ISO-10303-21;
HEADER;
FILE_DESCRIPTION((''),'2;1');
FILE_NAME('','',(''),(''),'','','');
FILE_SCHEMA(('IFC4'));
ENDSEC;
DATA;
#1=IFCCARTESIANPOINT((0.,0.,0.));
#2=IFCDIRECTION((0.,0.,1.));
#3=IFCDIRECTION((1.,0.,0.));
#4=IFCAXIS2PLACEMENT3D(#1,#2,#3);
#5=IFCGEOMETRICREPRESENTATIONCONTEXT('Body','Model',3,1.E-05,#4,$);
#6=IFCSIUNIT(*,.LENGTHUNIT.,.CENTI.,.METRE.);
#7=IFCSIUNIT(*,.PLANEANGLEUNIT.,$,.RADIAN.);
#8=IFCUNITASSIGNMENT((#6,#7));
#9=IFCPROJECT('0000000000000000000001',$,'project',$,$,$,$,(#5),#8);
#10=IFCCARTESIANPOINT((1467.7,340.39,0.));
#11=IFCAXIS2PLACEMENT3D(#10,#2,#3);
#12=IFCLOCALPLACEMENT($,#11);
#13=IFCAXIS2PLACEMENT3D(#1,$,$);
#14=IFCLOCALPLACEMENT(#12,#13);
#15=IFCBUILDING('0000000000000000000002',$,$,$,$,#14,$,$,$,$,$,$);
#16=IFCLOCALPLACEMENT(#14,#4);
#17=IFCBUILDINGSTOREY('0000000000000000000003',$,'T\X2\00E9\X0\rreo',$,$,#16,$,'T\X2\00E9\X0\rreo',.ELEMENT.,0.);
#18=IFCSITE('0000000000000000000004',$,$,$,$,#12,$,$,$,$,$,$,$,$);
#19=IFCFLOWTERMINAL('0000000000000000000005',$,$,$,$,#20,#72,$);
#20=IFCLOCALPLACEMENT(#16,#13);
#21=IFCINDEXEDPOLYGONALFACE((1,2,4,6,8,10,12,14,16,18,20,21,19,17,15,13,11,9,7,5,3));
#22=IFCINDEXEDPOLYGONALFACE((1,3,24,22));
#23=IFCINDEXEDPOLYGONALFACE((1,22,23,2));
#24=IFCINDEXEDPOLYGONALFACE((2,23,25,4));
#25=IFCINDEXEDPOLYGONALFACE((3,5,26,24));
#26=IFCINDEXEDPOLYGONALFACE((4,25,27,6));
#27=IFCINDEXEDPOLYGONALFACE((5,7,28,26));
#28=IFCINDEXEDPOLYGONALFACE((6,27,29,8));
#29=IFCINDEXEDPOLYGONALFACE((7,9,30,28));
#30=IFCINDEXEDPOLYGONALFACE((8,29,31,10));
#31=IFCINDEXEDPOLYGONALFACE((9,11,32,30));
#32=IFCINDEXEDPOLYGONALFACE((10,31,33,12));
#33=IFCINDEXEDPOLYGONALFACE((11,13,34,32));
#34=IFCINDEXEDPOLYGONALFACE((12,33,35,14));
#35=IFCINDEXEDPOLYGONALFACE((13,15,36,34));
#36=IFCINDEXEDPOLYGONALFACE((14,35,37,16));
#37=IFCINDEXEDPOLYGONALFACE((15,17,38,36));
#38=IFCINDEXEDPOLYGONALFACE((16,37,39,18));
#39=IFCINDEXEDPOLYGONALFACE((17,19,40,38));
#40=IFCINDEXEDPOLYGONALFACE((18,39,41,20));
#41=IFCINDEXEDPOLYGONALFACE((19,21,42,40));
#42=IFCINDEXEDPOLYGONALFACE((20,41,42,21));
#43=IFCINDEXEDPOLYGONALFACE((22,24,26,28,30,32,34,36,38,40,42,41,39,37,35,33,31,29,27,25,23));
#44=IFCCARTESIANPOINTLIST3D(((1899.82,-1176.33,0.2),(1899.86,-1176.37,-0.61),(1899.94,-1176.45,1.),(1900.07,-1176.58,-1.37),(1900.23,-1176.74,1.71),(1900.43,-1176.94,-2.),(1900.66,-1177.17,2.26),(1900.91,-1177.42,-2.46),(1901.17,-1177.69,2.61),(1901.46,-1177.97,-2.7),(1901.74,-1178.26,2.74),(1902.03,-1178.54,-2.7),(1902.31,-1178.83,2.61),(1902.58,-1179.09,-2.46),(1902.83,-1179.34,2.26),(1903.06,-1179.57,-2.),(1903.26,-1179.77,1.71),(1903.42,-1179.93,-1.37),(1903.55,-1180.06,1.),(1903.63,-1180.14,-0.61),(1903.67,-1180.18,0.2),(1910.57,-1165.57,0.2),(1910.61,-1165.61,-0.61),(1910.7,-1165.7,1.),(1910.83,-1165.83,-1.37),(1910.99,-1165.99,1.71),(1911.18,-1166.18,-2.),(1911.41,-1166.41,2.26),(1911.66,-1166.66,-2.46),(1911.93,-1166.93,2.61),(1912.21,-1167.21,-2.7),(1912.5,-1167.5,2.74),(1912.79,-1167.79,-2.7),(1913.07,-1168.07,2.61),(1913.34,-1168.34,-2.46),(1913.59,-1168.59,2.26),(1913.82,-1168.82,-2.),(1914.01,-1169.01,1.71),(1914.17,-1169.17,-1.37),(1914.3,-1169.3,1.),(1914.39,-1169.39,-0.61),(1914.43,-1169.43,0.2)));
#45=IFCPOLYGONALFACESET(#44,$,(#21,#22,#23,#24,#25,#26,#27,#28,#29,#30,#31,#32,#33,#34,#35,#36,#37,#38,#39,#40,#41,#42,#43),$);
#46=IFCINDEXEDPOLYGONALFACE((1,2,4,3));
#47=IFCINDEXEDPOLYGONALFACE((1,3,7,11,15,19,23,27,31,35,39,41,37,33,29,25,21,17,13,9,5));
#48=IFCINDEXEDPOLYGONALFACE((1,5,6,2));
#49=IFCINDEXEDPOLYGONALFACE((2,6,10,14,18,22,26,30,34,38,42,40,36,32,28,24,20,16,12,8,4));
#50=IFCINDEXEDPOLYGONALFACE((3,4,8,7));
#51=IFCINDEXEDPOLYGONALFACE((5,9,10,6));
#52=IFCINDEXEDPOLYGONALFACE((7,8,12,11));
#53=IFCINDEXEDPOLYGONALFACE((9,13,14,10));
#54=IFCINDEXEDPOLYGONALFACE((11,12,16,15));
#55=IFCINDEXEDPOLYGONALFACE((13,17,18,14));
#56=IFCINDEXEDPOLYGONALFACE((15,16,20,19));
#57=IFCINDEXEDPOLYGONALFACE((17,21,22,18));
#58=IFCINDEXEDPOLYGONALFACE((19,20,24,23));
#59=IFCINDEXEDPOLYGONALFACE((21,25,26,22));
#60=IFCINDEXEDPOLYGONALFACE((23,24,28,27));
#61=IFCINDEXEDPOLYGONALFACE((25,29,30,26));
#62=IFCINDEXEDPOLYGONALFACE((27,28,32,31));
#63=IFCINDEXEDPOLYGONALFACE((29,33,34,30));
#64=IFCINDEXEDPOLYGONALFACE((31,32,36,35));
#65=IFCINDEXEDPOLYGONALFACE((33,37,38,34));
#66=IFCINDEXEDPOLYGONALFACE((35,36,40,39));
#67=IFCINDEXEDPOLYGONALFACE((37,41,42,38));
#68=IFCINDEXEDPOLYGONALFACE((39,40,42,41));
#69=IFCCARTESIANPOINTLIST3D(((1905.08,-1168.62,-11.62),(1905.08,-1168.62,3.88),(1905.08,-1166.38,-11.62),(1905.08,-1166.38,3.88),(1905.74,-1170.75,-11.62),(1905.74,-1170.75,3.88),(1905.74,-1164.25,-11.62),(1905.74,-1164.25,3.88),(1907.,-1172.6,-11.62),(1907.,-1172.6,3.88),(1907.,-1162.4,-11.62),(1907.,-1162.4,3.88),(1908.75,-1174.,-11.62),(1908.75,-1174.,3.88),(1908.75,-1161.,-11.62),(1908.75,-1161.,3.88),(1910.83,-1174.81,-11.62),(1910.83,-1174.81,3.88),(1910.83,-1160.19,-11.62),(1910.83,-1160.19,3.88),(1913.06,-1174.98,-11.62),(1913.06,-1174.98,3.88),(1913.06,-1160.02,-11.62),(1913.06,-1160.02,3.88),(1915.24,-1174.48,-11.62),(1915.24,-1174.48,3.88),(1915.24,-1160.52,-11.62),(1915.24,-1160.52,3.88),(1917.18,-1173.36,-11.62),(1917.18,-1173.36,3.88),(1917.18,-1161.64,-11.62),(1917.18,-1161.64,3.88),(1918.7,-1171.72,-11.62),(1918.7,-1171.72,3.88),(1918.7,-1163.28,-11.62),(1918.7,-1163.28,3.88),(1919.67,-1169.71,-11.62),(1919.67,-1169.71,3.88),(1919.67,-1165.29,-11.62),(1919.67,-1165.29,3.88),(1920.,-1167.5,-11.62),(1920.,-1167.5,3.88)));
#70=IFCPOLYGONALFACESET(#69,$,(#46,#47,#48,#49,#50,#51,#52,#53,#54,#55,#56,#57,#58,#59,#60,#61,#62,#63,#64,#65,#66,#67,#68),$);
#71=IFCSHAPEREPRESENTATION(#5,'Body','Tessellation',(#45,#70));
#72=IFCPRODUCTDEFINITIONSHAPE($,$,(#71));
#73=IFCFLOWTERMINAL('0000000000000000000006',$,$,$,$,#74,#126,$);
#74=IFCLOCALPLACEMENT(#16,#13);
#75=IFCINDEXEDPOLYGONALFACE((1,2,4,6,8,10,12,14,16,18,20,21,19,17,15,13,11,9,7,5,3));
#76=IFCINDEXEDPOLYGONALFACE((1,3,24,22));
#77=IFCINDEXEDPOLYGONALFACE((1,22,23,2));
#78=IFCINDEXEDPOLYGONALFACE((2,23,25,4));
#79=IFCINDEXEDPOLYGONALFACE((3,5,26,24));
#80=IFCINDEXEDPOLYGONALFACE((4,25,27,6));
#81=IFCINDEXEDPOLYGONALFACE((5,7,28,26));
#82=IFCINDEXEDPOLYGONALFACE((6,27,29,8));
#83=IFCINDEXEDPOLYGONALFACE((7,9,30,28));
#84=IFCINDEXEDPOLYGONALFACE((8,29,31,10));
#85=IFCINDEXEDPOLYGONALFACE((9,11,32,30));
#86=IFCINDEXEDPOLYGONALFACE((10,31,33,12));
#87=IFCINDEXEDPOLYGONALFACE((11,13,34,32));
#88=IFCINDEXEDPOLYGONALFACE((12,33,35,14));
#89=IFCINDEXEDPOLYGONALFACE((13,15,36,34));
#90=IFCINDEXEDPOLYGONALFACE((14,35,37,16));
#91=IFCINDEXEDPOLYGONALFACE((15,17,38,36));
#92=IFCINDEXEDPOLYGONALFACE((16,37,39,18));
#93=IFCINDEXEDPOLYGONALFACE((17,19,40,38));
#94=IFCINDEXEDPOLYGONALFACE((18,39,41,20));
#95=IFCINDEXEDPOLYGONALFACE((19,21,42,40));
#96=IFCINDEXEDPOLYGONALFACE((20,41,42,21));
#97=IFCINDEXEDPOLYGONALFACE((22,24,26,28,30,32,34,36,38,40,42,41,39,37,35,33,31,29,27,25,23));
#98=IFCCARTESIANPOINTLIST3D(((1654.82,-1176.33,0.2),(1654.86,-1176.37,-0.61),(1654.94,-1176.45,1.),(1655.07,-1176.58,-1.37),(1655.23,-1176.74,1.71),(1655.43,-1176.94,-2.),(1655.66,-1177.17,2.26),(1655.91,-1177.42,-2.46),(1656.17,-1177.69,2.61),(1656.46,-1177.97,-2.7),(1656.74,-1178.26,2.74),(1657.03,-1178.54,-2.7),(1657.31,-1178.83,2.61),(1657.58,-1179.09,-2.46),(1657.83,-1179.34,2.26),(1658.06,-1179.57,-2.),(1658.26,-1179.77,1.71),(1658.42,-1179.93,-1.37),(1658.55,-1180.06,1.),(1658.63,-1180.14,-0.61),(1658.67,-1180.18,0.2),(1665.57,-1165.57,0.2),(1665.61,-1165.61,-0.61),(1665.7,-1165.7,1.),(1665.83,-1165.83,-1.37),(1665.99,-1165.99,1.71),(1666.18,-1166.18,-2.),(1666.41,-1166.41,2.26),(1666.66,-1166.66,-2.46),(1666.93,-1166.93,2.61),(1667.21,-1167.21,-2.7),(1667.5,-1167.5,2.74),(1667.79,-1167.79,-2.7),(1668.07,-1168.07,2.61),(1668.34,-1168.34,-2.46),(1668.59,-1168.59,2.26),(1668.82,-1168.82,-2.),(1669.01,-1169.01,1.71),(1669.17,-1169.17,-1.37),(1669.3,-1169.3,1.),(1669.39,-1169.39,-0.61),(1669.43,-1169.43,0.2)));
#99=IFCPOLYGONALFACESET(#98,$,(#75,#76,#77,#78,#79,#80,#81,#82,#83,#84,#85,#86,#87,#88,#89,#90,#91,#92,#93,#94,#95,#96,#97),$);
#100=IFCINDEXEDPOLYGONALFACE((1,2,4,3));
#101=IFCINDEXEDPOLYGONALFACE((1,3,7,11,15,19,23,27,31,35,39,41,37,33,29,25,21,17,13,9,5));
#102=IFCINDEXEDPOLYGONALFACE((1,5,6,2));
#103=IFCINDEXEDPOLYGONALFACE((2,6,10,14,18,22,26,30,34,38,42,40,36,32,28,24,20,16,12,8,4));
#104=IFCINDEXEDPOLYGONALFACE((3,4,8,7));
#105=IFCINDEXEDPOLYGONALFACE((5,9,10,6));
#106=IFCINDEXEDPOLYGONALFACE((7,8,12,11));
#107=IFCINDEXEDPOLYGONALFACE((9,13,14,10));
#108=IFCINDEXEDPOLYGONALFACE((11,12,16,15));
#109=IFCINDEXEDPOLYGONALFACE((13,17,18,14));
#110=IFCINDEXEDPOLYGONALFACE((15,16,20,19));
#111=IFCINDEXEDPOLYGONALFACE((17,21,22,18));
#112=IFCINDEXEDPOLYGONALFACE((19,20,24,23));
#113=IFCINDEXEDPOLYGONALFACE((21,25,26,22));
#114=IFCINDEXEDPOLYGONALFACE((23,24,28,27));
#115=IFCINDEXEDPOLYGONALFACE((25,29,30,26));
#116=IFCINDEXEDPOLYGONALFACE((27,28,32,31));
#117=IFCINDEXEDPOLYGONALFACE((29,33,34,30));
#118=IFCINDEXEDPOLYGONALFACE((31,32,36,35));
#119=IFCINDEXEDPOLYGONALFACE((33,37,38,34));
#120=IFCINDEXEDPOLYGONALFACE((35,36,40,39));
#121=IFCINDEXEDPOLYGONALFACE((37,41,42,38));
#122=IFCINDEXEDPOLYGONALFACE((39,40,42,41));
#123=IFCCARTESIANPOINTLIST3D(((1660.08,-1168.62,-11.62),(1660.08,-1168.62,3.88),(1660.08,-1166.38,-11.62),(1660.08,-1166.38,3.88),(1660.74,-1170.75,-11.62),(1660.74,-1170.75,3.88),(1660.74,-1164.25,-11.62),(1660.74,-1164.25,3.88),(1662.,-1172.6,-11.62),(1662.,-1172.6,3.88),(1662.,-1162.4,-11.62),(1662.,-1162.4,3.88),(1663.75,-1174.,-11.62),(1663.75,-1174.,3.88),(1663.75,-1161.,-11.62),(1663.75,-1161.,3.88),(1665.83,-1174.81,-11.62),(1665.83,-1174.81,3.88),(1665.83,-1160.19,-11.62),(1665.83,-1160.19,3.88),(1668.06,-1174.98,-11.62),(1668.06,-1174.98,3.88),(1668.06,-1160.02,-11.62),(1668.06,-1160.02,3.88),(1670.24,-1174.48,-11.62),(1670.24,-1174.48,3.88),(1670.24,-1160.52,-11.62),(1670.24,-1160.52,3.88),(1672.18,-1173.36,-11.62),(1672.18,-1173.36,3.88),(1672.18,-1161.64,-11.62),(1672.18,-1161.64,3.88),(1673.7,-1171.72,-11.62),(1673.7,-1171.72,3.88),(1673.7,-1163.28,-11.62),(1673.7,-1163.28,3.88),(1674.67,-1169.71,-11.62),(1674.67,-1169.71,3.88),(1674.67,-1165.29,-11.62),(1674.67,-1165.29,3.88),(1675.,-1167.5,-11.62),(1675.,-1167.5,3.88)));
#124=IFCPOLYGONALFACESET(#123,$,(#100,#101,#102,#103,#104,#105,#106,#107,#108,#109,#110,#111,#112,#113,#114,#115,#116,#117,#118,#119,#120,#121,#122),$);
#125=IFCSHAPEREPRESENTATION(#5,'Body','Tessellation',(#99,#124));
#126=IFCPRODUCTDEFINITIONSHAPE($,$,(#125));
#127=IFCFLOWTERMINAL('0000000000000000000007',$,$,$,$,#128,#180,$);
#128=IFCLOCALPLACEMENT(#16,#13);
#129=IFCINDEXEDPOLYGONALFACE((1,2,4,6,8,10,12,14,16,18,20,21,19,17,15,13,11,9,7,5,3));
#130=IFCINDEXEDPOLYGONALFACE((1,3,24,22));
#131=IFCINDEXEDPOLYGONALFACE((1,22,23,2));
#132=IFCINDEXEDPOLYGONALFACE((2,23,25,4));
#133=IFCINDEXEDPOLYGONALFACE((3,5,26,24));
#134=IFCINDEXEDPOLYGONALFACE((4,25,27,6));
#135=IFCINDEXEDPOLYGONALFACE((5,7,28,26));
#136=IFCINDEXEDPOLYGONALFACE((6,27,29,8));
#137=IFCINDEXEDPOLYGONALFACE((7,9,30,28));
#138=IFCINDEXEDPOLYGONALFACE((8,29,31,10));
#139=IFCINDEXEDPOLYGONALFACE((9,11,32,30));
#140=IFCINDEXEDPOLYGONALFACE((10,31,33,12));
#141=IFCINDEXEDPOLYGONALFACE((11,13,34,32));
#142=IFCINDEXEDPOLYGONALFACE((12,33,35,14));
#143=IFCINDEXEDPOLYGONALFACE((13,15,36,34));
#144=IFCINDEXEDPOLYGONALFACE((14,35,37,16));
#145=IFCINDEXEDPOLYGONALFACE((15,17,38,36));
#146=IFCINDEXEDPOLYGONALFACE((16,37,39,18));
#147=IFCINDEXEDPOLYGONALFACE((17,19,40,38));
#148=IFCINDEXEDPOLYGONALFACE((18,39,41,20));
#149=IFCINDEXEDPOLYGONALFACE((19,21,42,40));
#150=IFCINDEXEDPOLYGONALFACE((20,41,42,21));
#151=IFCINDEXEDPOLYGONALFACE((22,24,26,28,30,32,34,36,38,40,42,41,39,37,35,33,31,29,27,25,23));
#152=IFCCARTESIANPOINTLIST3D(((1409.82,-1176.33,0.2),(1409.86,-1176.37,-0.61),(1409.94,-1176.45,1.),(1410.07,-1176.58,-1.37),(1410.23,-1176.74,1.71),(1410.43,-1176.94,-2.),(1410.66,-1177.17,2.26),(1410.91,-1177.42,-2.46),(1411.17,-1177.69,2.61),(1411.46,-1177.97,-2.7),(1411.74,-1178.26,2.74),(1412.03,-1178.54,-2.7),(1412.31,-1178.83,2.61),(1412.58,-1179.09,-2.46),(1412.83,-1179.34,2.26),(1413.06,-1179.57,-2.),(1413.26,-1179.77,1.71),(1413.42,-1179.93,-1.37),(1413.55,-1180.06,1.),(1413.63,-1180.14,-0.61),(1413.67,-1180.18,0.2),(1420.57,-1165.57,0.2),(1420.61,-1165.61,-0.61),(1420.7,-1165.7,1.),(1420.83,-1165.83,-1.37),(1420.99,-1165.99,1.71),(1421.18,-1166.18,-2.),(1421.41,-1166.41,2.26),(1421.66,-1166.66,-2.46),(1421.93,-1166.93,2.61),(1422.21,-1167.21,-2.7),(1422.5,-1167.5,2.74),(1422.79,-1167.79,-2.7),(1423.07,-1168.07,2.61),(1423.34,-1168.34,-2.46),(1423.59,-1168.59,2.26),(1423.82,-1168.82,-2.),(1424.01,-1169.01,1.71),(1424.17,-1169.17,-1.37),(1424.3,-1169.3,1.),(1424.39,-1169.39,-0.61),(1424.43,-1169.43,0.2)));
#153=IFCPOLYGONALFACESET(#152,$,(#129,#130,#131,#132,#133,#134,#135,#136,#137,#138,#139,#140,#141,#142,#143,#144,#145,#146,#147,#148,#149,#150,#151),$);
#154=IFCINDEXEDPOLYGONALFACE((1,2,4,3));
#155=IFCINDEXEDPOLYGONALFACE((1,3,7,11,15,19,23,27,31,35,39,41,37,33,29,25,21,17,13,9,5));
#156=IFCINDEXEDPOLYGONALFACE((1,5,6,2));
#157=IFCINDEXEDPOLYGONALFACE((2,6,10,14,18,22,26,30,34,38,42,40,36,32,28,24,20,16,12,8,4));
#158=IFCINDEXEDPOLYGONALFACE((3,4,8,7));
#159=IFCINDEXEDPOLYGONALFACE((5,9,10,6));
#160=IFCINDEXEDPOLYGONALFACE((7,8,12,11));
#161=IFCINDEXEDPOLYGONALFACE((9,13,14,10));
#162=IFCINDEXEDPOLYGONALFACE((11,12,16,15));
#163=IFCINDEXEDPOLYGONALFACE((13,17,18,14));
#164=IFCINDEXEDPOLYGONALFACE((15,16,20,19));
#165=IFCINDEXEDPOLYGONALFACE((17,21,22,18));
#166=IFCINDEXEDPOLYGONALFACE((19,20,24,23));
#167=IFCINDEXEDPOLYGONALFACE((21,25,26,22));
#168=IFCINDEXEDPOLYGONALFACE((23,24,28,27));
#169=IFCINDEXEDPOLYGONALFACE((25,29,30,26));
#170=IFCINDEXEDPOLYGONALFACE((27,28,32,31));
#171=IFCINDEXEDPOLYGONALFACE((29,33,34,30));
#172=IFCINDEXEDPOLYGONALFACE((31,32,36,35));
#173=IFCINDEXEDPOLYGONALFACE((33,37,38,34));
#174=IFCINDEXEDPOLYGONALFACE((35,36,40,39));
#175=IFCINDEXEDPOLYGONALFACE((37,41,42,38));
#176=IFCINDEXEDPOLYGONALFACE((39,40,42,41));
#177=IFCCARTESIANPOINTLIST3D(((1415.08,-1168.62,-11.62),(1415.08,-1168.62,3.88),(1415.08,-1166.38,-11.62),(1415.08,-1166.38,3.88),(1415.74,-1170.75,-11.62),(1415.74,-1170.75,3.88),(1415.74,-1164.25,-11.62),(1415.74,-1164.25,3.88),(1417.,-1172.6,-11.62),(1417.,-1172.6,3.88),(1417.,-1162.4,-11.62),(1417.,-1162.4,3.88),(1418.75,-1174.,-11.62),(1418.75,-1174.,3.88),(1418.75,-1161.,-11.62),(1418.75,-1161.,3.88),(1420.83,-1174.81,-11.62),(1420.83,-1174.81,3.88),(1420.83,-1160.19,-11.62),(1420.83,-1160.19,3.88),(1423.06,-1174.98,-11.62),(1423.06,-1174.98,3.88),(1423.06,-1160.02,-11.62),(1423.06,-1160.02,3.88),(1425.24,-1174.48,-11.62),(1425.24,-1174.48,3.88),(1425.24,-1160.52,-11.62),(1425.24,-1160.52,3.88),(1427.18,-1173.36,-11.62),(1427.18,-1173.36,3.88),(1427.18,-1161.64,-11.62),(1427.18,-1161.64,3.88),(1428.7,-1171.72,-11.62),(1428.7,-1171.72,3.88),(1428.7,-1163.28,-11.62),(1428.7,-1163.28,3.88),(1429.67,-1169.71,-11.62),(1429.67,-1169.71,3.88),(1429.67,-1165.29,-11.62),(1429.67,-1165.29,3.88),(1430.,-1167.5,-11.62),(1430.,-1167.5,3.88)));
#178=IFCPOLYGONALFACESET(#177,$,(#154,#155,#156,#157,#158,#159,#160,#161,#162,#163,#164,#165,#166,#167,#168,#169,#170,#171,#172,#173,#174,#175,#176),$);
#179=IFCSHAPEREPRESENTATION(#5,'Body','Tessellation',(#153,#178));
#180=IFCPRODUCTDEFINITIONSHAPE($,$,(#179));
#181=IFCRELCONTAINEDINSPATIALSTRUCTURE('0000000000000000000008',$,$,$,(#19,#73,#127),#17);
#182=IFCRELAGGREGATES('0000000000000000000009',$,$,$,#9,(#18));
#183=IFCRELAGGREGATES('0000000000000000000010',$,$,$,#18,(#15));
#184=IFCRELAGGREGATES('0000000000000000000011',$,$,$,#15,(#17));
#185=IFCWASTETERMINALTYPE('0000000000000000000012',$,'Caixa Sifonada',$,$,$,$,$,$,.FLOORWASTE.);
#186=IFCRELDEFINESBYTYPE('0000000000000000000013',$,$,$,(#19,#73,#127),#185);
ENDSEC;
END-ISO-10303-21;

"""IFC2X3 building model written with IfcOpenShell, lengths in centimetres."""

from ifc_helpers import new_model, si_unit, frame, origin, origin_with_axes, origin_2d_with_axis, place, context, project, spatial, circle, extrude, type_object, element, save


model = new_model("IFC2X3")

# Units and contexts
model_context = context("Model", 3, precision=1e-05, world=origin_with_axes(), identifier="Body")
ifc_project = project(units=[si_unit("LENGTHUNIT", "METRE", prefix="CENTI"), si_unit("PLANEANGLEUNIT", "RADIAN")], contexts=[model_context])

# Site, building, storey
site_placement = place(None, frame((1467.7, 340.39, 0.0), z_axis=(0.0, 0.0, 1.0), x_axis=(1.0, 0.0, 0.0)))
site = spatial("IfcSite", under=ifc_project, at=site_placement)
building_placement = place(site_placement, origin())
building = spatial("IfcBuilding", under=site, at=building_placement)
storey_placement = place(building_placement, origin_with_axes())
storey = spatial("IfcBuildingStorey", under=building, at=storey_placement, Name="Térreo", LongName="Térreo", CompositionType="ELEMENT", Elevation=0.0)

# Flow terminals
waste_terminal_type_1 = type_object("IfcWasteTerminalType", Name="Caixa Sifonada", PredefinedType="FLOORWASTE")
for number, where, z_axis, x_axis in (
    (1, (1909.91, -1170.09, 3.88), (0.0, 0.0, 1.0), (1.0, 0.0, 0.0)),
    (2, (1664.91, -1170.09, 3.88), (0.0, 0.0, 1.0), (1.0, 0.0, 0.0)),
):
    element("IfcFlowTerminal", number, at=place(storey_placement, frame(where, z_axis=z_axis, x_axis=x_axis)), inside=storey, type_object=waste_terminal_type_1, context=model_context, shape_type="SolidModel", body=[
        extrude(circle(Radius=2.73, at=origin_2d_with_axis()), frame((2.59, 2.59, -3.88), z_axis=(-0.707107, -0.707107, 0.0), x_axis=(0.0, 0.0, 1.0)), (0.0, 0.0, 1.0), 15.21),
        extrude(circle(Radius=7.5, at=origin_2d_with_axis()), frame((2.59, 2.59, -15.5), z_axis=(0.0, 0.0, 1.0), x_axis=(1.0, 0.0, 0.0)), (0.0, 0.0, 1.0), 15.5),
    ])
flow_terminal_1_placement = place(storey_placement, frame((1419.91, -1170.09, 3.88), z_axis=(0.0, 0.0, 1.0), x_axis=(1.0, 0.0, 0.0)))
element("IfcFlowTerminal", 3, at=flow_terminal_1_placement, inside=storey, type_object=waste_terminal_type_1, context=model_context, shape_type="SolidModel", body=[
    extrude(circle(Radius=2.73, at=origin_2d_with_axis()), frame((2.59, 2.59, -3.88), z_axis=(-0.707107, -0.707107, 0.0), x_axis=(0.0, 0.0, 1.0)), (0.0, 0.0, 1.0), 15.21),
    extrude(circle(Radius=7.5, at=origin_2d_with_axis()), frame((2.59, 2.59, -15.5), z_axis=(0.0, 0.0, 1.0), x_axis=(1.0, 0.0, 0.0)), (0.0, 0.0, 1.0), 15.5),
])

save(model, "model.ifc")
